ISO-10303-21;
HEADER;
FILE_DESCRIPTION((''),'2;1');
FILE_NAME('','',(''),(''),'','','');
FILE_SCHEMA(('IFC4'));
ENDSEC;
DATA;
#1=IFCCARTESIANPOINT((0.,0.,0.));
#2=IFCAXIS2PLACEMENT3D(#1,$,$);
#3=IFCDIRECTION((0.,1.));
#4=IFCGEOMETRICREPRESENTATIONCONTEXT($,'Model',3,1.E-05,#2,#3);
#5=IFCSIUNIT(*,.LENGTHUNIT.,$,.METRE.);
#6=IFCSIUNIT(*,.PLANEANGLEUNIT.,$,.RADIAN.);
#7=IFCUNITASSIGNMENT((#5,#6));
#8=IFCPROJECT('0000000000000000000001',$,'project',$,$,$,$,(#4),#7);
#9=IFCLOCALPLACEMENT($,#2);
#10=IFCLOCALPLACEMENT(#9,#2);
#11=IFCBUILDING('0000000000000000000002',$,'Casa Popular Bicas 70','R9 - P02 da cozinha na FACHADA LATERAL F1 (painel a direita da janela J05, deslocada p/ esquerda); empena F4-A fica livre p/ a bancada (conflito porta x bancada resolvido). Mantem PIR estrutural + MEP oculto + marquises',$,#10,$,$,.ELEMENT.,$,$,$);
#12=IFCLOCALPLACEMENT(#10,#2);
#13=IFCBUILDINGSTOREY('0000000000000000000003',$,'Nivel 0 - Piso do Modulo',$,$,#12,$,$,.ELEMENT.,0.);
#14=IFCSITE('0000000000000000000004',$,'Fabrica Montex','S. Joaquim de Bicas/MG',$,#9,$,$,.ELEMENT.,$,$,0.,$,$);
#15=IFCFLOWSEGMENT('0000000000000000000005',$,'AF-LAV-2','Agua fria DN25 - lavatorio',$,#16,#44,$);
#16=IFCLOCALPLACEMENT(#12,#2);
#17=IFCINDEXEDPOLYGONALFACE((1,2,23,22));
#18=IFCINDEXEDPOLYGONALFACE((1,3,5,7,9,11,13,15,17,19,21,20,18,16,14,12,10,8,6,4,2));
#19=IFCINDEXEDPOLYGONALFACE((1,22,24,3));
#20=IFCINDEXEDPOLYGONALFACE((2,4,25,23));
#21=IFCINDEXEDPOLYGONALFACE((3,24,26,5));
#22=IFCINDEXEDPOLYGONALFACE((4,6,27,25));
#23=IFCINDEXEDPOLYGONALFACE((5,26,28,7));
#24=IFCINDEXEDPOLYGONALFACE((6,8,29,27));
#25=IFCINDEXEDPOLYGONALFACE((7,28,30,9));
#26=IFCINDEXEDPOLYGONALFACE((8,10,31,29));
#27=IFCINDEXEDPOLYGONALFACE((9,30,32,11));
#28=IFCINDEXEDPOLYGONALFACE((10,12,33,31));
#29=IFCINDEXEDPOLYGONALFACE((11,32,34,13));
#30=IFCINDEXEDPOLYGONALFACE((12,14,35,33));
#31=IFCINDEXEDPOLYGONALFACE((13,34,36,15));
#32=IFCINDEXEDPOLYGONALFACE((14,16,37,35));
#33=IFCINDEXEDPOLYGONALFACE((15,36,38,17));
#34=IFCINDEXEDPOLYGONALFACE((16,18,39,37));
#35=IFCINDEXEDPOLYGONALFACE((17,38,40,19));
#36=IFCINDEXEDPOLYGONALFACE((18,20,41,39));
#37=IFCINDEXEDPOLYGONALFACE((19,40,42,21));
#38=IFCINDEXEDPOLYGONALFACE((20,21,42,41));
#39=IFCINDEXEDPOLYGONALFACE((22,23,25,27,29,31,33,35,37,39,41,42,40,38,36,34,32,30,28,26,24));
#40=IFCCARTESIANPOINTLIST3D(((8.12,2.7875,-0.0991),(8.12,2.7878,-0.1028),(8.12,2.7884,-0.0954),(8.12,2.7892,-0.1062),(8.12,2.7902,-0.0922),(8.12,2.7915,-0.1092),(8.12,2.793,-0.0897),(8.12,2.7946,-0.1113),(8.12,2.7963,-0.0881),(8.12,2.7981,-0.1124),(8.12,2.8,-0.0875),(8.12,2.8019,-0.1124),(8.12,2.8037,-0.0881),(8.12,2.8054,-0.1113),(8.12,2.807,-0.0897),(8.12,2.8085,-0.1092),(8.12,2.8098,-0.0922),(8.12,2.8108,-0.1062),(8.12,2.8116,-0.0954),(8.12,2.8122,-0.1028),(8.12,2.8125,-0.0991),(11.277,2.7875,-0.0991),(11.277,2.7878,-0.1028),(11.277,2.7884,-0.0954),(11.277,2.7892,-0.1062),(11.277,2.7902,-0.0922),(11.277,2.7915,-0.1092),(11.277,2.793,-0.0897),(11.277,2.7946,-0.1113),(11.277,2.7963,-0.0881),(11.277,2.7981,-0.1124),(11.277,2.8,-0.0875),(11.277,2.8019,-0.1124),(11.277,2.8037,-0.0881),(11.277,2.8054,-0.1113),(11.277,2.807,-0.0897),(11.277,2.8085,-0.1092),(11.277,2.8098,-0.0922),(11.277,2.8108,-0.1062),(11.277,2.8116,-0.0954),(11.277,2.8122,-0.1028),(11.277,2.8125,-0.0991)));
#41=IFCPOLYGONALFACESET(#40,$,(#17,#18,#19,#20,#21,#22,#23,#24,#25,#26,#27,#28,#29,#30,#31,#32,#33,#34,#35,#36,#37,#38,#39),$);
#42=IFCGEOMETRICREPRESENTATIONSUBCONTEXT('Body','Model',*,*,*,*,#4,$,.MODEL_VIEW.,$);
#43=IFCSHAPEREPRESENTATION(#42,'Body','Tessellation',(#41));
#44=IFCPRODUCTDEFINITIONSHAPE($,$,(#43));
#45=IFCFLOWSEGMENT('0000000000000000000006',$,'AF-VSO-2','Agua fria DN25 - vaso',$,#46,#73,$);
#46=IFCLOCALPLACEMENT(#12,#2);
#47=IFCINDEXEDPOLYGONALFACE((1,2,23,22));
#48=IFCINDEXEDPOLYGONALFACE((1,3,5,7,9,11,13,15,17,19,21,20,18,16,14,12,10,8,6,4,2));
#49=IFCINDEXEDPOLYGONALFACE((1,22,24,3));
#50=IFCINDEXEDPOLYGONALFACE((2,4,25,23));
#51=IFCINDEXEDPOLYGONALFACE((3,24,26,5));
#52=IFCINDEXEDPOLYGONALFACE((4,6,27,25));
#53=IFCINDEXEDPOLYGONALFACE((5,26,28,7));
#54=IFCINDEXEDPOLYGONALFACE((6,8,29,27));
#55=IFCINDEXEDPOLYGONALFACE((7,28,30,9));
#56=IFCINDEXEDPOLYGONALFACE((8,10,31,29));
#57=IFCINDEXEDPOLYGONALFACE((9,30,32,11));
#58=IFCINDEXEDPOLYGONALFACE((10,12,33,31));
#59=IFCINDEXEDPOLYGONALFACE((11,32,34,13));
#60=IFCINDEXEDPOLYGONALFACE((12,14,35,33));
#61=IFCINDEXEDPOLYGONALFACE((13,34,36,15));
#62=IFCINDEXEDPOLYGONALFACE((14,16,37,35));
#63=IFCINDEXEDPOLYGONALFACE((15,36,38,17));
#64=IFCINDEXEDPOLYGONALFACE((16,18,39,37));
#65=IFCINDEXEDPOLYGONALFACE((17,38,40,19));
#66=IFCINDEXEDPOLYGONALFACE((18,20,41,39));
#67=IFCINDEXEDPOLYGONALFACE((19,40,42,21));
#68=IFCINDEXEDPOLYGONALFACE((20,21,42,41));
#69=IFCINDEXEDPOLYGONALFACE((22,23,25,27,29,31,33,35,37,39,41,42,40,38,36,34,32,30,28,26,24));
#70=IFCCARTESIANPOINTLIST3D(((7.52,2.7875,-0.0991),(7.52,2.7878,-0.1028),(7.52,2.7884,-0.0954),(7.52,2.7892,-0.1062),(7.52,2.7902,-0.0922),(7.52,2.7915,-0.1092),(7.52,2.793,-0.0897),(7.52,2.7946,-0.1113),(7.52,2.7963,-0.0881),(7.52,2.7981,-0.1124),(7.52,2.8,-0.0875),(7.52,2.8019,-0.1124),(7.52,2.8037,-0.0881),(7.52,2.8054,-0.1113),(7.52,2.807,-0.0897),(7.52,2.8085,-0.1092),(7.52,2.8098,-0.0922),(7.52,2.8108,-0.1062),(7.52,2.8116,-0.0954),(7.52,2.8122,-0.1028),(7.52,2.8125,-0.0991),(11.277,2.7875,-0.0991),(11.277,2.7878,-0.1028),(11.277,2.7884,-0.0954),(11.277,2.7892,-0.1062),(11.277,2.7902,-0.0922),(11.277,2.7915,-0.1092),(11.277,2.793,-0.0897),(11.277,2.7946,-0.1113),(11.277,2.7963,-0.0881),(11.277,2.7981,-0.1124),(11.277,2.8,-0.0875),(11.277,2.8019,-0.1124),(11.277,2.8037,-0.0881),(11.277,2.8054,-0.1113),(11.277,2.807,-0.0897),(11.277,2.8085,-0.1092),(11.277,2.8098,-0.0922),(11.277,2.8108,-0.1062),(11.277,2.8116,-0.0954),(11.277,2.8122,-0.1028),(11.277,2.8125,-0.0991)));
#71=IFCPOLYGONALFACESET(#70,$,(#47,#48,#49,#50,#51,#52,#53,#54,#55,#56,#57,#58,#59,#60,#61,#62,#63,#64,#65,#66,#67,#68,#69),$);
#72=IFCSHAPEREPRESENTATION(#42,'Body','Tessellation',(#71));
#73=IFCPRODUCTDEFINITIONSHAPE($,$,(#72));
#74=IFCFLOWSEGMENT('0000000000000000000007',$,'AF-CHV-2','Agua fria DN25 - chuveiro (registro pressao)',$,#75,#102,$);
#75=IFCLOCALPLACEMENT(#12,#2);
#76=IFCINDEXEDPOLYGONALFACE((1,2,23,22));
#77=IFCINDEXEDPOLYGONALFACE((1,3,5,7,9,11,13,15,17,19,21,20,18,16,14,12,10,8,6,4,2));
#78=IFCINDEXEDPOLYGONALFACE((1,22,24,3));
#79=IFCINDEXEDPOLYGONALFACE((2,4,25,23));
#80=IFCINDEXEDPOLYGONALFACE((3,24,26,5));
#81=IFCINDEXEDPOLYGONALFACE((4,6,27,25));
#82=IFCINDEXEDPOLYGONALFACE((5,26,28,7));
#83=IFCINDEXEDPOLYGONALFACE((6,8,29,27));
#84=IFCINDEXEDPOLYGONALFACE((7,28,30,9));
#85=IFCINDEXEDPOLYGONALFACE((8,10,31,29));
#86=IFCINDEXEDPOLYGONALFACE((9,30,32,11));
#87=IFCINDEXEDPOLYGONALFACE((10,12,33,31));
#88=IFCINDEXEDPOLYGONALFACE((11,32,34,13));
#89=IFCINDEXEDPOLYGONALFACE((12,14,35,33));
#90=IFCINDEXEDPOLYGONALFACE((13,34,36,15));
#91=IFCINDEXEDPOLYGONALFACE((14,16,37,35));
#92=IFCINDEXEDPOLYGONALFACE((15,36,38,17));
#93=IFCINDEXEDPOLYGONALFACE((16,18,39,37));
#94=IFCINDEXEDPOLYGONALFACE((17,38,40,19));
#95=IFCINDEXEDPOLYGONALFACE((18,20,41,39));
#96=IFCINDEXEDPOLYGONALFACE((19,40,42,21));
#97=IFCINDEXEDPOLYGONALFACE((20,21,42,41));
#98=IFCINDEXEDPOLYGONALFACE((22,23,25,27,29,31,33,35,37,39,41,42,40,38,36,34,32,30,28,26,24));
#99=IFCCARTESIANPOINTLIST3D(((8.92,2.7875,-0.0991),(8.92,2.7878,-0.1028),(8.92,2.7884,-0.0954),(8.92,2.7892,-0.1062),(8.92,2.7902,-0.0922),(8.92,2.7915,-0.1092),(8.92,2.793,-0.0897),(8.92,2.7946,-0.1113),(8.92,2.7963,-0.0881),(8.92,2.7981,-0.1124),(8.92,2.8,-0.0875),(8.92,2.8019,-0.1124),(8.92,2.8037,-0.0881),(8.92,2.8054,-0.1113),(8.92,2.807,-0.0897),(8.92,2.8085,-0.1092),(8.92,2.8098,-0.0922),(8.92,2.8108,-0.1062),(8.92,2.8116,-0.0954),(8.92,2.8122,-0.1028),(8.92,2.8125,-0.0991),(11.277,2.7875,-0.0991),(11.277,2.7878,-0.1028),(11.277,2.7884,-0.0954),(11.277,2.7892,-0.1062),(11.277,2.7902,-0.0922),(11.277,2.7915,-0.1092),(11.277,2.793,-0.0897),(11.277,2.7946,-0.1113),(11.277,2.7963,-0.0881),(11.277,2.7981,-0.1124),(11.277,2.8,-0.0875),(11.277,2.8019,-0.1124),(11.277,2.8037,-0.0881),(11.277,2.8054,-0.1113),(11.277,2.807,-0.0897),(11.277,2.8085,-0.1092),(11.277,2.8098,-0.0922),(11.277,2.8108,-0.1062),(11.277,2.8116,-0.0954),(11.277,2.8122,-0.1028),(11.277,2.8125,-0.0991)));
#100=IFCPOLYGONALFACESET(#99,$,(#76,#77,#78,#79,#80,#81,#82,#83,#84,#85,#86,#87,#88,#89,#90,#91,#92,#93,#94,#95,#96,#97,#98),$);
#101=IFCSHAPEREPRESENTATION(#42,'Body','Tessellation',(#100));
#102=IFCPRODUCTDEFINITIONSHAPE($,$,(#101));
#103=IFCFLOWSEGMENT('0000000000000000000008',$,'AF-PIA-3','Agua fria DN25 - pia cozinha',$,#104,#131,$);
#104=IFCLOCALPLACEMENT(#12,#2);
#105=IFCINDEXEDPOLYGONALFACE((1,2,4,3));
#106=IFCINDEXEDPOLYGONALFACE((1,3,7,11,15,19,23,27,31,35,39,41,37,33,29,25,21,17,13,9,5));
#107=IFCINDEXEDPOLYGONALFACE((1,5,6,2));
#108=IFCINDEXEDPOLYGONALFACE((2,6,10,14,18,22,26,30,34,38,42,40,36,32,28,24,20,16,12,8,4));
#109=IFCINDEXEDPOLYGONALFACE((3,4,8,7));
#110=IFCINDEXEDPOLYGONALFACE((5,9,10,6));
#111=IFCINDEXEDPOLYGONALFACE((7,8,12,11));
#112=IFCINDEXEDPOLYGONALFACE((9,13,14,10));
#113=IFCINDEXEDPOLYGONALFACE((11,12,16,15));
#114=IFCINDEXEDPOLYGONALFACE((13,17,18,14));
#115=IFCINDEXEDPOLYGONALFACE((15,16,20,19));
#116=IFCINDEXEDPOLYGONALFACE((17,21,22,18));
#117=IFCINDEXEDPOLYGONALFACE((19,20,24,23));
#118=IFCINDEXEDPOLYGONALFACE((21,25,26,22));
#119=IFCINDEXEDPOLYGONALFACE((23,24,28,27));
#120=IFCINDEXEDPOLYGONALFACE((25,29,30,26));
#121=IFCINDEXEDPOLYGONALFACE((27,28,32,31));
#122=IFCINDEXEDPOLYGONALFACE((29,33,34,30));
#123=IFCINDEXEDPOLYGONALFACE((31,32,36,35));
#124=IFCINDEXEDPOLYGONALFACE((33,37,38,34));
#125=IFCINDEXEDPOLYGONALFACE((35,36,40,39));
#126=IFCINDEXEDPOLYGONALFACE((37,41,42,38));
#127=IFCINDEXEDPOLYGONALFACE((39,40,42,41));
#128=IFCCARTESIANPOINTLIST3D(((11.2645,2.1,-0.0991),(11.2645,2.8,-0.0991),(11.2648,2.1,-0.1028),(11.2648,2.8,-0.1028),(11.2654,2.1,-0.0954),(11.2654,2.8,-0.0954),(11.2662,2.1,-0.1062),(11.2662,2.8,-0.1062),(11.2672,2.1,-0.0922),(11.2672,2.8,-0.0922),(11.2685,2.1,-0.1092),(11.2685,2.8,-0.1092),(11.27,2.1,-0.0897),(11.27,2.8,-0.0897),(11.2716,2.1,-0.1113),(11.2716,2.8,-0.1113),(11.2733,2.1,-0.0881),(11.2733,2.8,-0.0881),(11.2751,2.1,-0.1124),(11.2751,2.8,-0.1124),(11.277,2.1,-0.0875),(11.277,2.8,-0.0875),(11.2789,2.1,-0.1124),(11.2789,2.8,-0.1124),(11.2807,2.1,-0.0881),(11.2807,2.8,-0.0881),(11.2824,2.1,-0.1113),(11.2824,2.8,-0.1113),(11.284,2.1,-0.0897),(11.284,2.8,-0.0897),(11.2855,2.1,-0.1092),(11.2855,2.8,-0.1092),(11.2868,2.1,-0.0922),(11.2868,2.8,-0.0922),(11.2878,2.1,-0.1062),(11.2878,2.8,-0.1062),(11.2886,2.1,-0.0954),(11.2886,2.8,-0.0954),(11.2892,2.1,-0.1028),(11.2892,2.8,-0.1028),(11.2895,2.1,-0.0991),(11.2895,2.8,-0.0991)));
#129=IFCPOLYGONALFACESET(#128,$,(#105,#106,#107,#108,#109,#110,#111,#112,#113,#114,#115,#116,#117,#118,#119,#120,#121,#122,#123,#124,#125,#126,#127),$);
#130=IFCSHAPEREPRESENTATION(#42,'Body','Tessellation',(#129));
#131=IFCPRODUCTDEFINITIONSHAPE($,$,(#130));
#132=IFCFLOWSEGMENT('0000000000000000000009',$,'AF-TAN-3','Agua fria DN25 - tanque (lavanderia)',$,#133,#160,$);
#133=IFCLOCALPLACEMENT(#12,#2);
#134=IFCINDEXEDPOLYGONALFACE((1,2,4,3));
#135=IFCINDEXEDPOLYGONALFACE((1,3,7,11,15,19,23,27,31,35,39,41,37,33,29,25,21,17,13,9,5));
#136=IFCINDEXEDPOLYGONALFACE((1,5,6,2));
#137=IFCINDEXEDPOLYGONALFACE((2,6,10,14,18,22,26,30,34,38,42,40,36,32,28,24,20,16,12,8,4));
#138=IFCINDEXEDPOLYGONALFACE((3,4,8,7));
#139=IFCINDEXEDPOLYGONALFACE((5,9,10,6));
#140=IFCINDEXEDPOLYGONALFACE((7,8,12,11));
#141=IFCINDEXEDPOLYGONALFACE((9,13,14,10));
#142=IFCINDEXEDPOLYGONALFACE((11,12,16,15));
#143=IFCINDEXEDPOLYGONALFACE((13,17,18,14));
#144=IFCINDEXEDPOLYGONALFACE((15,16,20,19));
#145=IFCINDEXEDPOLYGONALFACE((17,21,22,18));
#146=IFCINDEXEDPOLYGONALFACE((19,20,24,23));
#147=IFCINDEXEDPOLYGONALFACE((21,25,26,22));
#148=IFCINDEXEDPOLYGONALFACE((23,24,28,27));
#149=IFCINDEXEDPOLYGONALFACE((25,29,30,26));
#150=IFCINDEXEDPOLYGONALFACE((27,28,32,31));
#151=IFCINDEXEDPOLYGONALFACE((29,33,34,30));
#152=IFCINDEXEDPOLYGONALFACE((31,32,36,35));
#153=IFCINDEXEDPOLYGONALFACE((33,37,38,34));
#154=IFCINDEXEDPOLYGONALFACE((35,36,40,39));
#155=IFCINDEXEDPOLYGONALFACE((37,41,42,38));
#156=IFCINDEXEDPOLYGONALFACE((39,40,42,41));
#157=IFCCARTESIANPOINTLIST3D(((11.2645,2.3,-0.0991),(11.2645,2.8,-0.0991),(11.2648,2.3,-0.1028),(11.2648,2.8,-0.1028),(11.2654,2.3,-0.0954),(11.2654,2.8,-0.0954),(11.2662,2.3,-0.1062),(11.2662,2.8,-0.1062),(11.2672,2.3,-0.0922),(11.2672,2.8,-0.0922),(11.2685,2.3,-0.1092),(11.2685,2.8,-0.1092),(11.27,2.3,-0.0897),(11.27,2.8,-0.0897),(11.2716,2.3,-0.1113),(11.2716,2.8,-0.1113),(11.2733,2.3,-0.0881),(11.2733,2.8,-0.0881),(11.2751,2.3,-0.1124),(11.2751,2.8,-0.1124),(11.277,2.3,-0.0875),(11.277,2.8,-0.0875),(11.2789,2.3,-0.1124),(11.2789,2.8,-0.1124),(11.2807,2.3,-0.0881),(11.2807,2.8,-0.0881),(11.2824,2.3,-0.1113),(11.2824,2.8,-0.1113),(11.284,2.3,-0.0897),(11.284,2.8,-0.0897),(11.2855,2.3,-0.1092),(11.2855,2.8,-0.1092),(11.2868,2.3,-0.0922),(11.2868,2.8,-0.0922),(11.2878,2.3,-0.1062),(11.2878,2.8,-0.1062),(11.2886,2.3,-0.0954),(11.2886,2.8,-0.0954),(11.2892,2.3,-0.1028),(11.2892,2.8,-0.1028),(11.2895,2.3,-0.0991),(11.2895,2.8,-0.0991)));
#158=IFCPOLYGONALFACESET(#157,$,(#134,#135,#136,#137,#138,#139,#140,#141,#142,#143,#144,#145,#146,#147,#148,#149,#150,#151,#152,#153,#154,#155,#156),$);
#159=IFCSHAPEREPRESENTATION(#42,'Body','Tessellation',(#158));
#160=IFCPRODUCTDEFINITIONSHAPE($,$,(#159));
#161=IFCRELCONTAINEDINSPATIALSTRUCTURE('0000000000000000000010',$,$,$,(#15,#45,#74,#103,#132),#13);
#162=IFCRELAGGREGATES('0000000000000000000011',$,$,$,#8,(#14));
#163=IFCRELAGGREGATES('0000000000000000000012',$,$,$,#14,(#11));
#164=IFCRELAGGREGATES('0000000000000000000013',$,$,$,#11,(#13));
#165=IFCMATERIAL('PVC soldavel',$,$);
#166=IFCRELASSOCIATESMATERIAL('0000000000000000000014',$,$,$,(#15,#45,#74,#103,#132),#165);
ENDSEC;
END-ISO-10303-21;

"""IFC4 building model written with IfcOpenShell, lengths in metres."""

from ifc_helpers import new_model, si_unit, direction, frame, origin, origin_2d, place, context, subcontext, project, spatial, circle, extrude, material, element, save


model = new_model("IFC4")

# Units and contexts
model_context = context("Model", 3, precision=1e-05, world=origin(), true_north=direction((0.0, 1.0)))
body_context = subcontext(model_context, "Body", "Model", "MODEL_VIEW")
ifc_project = project(units=[si_unit("LENGTHUNIT", "METRE"), si_unit("PLANEANGLEUNIT", "RADIAN")], contexts=[model_context])

# Site, building, storey
site_placement = place(None, origin())
site = spatial("IfcSite", under=ifc_project, at=site_placement, Name="Fabrica Montex", Description="S. Joaquim de Bicas/MG", CompositionType="ELEMENT", RefElevation=0.0)
building_placement = place(site_placement, origin())
building = spatial("IfcBuilding", under=site, at=building_placement, Name="Casa Popular Bicas 70", Description="R9 - P02 da cozinha na FACHADA LATERAL F1 (painel a direita da janela J05, deslocada p/ esquerda); empena F4-A fica livre p/ a bancada (conflito porta x bancada resolvido). Mantem PIR estrutural + MEP oculto + marquises", CompositionType="ELEMENT")
storey_placement = place(building_placement, origin())
storey = spatial("IfcBuildingStorey", under=building, at=storey_placement, Name="Nivel 0 - Piso do Modulo", CompositionType="ELEMENT", Elevation=0.0)

# Flow segments
ifc_material_1 = material(Name="PVC soldavel")
flow_segment_1_placement = place(None, frame((11.277, 2.8, -0.1), z_axis=(-1.0, 0.0, 0.0), x_axis=(0.0, 0.0, 1.0)))
element("IfcFlowSegment", 1, at=flow_segment_1_placement, inside=storey, material=ifc_material_1, Name="AF-LAV-2", Description="Agua fria DN25 - lavatorio", context=body_context, shape_type="SweptSolid", body=[
    extrude(circle(Radius=0.0125, at=origin_2d()), origin(), (0.0, 0.0, 1.0), 3.157),
])
flow_segment_2_placement = place(None, frame((11.277, 2.8, -0.1), z_axis=(-1.0, 0.0, 0.0), x_axis=(0.0, 0.0, 1.0)))
element("IfcFlowSegment", 2, at=flow_segment_2_placement, inside=storey, material=ifc_material_1, Name="AF-VSO-2", Description="Agua fria DN25 - vaso", context=body_context, shape_type="SweptSolid", body=[
    extrude(circle(Radius=0.0125, at=origin_2d()), origin(), (0.0, 0.0, 1.0), 3.757),
])
flow_segment_3_placement = place(None, frame((11.277, 2.8, -0.1), z_axis=(-1.0, 0.0, 0.0), x_axis=(0.0, 0.0, 1.0)))
element("IfcFlowSegment", 3, at=flow_segment_3_placement, inside=storey, material=ifc_material_1, Name="AF-CHV-2", Description="Agua fria DN25 - chuveiro (registro pressao)", context=body_context, shape_type="SweptSolid", body=[
    extrude(circle(Radius=0.0125, at=origin_2d()), origin(), (0.0, 0.0, 1.0), 2.357),
])
flow_segment_4_placement = place(None, frame((11.277, 2.8, -0.1), z_axis=(0.0, -1.0, 0.0), x_axis=(0.0, 0.0, 1.0)))
element("IfcFlowSegment", 4, at=flow_segment_4_placement, inside=storey, material=ifc_material_1, Name="AF-PIA-3", Description="Agua fria DN25 - pia cozinha", context=body_context, shape_type="SweptSolid", body=[
    extrude(circle(Radius=0.0125, at=origin_2d()), origin(), (0.0, 0.0, 1.0), 0.7),
])
flow_segment_5_placement = place(None, frame((11.277, 2.8, -0.1), z_axis=(0.0, -1.0, 0.0), x_axis=(0.0, 0.0, 1.0)))
element("IfcFlowSegment", 5, at=flow_segment_5_placement, inside=storey, material=ifc_material_1, Name="AF-TAN-3", Description="Agua fria DN25 - tanque (lavanderia)", context=body_context, shape_type="SweptSolid", body=[
    extrude(circle(Radius=0.0125, at=origin_2d()), origin(), (0.0, 0.0, 1.0), 0.5),
])

save(model, "model.ifc")
